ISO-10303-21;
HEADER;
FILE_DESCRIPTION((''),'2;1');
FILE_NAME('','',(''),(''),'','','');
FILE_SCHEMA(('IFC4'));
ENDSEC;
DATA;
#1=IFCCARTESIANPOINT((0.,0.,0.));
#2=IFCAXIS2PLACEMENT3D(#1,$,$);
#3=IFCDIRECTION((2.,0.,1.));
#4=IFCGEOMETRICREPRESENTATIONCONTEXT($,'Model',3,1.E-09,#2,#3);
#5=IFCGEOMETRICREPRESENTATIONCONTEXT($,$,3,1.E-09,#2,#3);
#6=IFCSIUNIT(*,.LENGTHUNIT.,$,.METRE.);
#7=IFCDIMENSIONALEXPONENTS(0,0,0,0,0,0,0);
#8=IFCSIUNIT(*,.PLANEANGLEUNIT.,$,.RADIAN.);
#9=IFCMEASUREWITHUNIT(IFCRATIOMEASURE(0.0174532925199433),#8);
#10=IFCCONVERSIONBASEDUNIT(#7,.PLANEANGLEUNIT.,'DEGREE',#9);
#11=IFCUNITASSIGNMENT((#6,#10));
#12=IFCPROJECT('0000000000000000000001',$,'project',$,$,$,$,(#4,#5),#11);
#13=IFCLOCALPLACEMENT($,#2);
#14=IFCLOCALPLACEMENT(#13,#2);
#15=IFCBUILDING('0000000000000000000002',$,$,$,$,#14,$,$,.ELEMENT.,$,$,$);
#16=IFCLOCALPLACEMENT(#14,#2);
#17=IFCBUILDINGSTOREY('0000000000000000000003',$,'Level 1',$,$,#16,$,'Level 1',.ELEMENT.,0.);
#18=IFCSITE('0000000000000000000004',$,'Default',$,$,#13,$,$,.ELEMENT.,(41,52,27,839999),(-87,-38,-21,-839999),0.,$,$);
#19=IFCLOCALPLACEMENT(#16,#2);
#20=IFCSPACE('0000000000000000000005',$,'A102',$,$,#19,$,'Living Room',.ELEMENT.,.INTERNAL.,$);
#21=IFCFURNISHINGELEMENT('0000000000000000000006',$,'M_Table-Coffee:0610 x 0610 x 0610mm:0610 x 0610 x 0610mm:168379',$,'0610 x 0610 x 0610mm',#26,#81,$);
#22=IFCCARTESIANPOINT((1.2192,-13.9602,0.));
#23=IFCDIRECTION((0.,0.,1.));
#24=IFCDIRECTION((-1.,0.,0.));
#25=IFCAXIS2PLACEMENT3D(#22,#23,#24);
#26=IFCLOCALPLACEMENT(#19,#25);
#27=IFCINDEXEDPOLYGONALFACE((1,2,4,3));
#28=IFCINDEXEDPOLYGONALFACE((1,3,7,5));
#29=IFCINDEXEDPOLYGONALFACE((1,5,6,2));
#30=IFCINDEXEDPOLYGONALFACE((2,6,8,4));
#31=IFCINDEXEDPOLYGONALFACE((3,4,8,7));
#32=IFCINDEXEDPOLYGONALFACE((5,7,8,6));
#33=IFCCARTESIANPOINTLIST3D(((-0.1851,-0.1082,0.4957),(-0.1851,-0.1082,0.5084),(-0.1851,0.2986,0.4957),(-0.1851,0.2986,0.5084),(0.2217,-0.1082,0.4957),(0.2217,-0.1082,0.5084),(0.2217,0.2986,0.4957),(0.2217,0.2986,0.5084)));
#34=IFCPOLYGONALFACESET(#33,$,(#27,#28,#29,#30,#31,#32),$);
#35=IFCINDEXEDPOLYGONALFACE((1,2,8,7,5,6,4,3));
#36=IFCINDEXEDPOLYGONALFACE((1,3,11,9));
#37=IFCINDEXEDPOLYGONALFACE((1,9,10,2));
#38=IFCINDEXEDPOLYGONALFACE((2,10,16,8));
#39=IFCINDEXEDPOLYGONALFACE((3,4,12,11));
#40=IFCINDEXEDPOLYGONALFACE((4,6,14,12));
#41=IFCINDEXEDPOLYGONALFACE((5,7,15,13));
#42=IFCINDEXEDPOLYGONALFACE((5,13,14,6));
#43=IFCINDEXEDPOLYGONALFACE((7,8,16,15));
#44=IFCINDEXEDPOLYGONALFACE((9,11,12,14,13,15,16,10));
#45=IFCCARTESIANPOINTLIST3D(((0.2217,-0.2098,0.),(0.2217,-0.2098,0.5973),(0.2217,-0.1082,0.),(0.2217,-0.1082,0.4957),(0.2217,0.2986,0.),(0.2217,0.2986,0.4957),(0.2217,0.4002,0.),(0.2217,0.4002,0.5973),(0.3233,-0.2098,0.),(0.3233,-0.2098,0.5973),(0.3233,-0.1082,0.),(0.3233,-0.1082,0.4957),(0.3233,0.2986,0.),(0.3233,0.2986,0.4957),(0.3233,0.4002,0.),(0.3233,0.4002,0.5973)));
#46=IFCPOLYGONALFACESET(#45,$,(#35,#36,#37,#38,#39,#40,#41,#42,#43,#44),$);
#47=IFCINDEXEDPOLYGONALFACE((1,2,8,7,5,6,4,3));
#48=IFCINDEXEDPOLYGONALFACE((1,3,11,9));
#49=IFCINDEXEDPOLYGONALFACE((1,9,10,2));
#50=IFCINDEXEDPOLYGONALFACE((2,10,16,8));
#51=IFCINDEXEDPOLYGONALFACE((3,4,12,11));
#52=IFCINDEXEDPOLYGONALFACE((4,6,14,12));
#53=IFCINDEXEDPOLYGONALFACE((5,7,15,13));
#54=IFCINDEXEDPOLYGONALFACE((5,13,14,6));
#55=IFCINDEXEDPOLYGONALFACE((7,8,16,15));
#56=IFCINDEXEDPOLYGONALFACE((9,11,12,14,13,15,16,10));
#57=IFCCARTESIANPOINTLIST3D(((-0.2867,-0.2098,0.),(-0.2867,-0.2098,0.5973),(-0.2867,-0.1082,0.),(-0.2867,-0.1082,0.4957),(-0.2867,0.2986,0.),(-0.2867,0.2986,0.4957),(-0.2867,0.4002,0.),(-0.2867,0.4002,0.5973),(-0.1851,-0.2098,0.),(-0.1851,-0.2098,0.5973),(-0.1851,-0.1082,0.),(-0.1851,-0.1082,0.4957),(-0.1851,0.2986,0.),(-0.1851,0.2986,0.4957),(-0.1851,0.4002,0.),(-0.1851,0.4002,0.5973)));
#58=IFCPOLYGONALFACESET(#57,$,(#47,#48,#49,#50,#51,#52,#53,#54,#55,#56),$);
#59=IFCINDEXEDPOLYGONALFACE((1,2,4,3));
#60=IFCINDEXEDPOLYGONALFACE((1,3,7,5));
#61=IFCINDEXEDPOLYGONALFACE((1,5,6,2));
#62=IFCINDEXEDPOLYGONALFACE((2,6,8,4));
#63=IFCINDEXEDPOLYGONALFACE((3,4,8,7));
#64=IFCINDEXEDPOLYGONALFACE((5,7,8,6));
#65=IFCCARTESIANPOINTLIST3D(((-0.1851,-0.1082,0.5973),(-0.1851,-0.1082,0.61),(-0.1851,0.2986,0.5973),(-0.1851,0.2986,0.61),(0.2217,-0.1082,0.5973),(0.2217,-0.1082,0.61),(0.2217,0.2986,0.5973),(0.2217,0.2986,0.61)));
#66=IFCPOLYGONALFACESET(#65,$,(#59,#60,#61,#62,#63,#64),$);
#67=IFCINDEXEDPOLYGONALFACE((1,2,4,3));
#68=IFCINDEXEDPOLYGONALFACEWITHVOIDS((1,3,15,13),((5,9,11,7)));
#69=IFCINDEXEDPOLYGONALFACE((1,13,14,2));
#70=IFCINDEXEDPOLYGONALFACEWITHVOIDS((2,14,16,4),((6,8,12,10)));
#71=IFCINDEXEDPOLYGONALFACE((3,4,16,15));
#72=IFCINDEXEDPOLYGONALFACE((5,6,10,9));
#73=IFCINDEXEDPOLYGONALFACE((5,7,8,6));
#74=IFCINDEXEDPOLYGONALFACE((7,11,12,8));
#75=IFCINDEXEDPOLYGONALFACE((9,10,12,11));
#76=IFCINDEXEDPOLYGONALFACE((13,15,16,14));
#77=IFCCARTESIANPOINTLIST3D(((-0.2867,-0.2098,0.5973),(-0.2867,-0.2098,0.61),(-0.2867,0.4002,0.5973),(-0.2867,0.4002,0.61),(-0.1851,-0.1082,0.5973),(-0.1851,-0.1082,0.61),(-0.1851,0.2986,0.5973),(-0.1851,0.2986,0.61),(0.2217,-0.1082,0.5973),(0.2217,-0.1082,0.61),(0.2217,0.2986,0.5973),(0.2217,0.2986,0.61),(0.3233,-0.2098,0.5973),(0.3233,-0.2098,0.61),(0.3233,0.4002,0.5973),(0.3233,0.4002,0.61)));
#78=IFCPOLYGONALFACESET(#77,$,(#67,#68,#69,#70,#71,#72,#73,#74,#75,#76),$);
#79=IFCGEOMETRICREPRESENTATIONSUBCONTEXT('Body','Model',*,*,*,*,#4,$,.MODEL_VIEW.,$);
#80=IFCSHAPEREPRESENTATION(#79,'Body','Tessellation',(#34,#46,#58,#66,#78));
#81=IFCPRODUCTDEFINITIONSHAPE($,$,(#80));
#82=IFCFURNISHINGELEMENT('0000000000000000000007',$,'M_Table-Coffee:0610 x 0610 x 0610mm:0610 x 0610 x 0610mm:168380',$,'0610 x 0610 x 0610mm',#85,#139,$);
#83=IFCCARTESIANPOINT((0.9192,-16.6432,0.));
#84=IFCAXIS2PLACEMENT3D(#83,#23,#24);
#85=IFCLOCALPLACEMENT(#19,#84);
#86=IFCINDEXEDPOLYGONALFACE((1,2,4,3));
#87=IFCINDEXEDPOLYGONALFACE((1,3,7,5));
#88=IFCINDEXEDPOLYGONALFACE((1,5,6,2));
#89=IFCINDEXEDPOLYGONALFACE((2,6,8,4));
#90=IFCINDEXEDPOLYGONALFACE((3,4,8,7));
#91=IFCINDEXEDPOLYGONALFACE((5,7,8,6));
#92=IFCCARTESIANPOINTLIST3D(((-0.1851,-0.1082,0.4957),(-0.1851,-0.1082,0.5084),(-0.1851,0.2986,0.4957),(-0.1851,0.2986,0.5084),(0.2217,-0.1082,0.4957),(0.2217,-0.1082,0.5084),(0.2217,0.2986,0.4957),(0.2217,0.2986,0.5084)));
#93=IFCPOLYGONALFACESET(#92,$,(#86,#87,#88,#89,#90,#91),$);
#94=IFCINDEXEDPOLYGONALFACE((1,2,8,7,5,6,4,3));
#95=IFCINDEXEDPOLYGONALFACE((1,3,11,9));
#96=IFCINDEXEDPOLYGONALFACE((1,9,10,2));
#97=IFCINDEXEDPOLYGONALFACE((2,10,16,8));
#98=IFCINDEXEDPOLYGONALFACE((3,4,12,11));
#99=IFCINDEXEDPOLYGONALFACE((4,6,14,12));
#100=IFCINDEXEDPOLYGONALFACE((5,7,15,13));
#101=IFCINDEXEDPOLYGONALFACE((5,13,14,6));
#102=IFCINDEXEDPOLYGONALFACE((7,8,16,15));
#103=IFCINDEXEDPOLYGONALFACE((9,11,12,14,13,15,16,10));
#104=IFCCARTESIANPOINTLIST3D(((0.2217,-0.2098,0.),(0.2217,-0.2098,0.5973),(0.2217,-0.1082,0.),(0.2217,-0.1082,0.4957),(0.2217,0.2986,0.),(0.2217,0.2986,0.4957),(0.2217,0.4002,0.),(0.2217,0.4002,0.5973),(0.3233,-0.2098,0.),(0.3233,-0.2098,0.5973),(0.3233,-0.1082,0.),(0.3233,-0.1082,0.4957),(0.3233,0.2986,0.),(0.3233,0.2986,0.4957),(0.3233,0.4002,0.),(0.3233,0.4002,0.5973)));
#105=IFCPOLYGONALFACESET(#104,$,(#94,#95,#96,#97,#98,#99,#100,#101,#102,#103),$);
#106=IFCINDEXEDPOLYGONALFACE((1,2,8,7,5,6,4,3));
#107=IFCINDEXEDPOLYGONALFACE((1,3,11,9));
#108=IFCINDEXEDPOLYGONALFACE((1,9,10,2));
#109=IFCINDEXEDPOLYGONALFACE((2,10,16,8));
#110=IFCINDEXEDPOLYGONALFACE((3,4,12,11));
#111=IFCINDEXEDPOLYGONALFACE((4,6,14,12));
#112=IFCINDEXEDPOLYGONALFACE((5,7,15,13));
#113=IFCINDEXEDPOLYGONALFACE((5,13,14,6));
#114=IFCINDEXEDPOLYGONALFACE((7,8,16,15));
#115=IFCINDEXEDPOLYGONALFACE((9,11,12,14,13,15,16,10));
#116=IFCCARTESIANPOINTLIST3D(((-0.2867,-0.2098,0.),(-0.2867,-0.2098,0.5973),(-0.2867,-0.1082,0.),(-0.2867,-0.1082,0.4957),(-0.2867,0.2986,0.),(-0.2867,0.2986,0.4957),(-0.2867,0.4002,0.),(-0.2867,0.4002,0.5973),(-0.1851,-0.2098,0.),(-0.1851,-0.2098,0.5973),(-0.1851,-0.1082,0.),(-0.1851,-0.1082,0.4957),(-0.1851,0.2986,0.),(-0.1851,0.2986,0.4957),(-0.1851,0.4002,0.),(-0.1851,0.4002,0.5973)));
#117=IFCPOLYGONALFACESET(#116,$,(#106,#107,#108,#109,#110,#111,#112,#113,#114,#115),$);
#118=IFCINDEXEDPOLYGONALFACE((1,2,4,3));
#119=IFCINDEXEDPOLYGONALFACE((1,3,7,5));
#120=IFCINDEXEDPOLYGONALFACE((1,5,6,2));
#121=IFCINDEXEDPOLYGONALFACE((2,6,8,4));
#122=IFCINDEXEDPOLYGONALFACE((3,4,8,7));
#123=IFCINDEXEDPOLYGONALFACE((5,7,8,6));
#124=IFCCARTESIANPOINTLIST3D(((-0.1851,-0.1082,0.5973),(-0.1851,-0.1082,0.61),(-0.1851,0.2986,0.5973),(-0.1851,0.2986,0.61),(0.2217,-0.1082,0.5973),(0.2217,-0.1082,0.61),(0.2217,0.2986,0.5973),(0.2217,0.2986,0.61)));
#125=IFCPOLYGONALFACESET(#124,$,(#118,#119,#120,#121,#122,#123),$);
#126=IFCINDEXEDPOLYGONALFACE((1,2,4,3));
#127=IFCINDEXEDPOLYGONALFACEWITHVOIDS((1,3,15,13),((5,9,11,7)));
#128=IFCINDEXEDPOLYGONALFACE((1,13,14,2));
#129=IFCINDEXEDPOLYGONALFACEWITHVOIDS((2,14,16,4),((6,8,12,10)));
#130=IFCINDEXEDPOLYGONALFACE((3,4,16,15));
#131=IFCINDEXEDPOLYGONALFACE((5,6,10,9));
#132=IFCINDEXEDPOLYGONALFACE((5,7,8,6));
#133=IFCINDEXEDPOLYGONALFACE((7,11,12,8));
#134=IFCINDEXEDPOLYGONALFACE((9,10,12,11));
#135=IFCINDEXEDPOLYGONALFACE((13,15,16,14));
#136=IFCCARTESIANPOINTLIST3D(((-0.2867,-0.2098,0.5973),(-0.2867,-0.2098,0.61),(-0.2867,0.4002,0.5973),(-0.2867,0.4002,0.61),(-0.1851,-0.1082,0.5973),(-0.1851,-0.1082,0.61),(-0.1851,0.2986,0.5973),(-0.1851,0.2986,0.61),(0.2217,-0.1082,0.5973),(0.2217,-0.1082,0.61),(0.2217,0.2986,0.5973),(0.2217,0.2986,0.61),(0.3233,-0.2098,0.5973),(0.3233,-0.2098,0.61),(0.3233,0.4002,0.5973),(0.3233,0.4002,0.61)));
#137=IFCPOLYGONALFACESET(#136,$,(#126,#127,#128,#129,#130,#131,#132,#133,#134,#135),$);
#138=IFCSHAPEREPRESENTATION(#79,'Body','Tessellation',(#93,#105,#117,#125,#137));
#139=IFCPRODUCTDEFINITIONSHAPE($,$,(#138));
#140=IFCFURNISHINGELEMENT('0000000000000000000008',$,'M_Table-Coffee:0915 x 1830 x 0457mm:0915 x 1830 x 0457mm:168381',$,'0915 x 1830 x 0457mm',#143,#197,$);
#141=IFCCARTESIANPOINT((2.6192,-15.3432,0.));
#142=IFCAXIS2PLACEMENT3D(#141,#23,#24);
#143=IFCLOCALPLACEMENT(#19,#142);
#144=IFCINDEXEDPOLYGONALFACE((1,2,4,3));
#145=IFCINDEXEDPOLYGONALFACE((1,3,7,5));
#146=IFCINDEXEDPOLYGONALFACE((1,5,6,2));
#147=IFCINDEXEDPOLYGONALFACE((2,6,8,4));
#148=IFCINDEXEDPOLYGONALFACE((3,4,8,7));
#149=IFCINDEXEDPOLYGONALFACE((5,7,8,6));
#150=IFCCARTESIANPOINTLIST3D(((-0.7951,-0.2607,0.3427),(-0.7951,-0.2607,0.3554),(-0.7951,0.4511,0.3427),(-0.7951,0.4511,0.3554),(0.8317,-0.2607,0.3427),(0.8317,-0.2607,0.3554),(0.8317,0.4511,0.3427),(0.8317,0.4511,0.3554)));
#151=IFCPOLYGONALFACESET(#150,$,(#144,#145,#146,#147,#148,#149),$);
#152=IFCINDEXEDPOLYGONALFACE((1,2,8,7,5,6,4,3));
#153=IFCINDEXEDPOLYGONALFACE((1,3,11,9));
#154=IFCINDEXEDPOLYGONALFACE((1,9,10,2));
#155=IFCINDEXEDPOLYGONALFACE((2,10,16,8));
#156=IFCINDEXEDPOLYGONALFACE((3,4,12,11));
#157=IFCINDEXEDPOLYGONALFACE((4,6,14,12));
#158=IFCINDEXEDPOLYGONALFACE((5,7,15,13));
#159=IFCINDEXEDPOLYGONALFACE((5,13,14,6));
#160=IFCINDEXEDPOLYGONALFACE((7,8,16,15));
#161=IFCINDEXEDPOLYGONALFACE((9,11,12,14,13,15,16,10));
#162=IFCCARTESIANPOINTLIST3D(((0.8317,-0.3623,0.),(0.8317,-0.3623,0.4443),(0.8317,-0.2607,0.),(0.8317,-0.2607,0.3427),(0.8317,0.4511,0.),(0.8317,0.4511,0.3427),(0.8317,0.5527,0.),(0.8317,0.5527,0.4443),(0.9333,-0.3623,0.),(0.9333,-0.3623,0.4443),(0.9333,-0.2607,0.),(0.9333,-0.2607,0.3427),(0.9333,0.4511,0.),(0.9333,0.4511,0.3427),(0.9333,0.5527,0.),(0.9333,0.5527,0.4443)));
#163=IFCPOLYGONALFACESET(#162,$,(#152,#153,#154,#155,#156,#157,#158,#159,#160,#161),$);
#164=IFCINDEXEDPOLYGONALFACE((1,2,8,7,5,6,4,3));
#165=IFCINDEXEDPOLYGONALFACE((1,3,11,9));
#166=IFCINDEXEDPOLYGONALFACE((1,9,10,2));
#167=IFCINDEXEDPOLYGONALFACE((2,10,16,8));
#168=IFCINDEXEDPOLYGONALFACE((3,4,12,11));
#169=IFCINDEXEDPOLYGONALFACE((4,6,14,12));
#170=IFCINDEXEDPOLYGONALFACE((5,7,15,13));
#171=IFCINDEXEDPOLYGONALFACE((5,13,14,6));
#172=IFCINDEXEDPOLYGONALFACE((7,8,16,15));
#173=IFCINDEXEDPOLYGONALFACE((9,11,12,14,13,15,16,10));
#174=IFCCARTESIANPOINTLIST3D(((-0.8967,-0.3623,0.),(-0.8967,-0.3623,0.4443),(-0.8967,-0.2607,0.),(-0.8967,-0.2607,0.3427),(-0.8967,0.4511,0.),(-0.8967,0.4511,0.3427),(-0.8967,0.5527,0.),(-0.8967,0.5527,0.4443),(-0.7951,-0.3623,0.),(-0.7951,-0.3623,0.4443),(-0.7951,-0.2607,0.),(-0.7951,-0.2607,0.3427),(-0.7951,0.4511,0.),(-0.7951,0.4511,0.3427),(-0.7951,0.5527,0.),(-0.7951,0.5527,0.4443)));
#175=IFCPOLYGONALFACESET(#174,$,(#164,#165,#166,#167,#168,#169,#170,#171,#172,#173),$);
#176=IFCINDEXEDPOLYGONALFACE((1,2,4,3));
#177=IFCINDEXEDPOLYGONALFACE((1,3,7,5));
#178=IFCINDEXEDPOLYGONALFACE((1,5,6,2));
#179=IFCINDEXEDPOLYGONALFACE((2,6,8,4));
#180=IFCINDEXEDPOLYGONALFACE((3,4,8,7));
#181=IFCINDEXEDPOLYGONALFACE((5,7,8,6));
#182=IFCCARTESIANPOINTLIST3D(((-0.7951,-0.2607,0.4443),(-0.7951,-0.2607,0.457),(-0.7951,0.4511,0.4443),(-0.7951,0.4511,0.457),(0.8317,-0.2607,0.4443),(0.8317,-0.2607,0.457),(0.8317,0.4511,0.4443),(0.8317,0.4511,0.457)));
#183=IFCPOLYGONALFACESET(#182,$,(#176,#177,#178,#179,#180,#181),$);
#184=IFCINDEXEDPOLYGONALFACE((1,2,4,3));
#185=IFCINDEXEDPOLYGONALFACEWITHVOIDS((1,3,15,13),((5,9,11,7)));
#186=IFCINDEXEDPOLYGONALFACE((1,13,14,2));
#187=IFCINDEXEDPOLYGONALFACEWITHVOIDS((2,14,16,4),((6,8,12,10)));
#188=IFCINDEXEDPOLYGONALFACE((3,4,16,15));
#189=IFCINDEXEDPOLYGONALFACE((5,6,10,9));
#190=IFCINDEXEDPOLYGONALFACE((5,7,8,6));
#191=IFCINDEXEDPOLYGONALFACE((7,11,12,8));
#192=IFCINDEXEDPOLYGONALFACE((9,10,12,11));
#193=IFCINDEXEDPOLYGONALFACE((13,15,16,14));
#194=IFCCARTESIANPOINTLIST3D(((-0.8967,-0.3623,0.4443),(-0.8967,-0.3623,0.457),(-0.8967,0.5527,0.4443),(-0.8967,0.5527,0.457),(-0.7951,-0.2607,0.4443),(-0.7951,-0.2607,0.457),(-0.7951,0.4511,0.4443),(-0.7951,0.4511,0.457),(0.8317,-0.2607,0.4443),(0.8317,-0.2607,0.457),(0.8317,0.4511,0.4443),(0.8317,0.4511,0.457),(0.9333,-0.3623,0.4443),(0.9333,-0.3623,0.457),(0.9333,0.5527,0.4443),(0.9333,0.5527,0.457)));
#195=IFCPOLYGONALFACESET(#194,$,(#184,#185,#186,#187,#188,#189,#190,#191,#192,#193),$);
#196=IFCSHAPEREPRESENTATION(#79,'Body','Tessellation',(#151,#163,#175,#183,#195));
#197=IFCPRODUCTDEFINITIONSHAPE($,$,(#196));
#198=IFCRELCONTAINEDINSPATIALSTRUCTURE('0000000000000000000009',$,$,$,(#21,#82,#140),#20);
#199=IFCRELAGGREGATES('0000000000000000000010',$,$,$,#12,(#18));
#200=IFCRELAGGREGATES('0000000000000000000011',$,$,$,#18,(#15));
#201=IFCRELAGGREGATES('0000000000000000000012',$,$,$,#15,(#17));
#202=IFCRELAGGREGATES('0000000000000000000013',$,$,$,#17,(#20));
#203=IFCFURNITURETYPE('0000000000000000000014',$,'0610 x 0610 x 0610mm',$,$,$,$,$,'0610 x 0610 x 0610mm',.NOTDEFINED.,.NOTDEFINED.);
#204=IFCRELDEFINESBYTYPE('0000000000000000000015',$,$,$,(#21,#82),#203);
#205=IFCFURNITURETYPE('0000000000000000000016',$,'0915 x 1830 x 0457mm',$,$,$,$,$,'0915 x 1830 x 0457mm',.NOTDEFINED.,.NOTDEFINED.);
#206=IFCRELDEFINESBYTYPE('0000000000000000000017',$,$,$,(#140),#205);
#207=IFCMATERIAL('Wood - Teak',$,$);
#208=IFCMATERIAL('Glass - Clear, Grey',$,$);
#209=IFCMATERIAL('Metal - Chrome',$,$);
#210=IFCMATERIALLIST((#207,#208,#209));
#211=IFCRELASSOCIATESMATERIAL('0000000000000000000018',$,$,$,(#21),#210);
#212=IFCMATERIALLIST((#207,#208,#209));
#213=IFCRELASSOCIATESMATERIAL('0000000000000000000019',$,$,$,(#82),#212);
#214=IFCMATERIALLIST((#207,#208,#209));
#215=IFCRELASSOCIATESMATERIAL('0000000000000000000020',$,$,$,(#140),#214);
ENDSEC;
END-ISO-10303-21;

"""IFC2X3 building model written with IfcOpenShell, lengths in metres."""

from ifc_helpers import new_model, entity, si_unit, converted_unit, direction, frame, origin, origin_2d_with_axis, place, context, subcontext, project, spatial, polyline, rectangle, outline, extrude, source, transform, mapped, material, material_list, type_object, type_shapes, element, save


model = new_model("IFC2X3")

# Units and contexts
model_context = context("Model", 3, precision=1e-09, world=origin(), true_north=direction((2.0, 0.0, 1.0)))
context_of_model = context(None, 3, precision=1e-09, world=origin(), true_north=direction((2.0, 0.0, 1.0)))
body_context = subcontext(model_context, "Body", "Model", "MODEL_VIEW")
ifc_project = project(units=[si_unit("LENGTHUNIT", "METRE"), converted_unit("PLANEANGLEUNIT", "DEGREE", entity("IfcRatioMeasure", 0.0174532925199433), si_unit("PLANEANGLEUNIT", "RADIAN"), dimensions=[0, 0, 0, 0, 0, 0, 0])], contexts=[model_context, context_of_model])

# Site, building, storey
site_placement = place(None, origin())
site = spatial("IfcSite", under=ifc_project, at=site_placement, Name="Default", CompositionType="ELEMENT", RefLatitude=(41, 52, 27, 839999), RefLongitude=(-87, -38, -21, -839999), RefElevation=0.0)
building_placement = place(site_placement, origin())
building = spatial("IfcBuilding", under=site, at=building_placement, CompositionType="ELEMENT")
storey_placement = place(building_placement, origin())
storey = spatial("IfcBuildingStorey", under=building, at=storey_placement, Name="Level 1", LongName="Level 1", CompositionType="ELEMENT", Elevation=0.0)

# Shared definitions
space_1_placement = place(storey_placement, origin())
space_1 = spatial("IfcSpace", under=storey, at=space_1_placement, Name="A102", LongName="Living Room", CompositionType="ELEMENT", InteriorOrExteriorSpace="INTERNAL")

# Furnishing elements
ifc_material_1 = material(Name="Wood - Teak")
ifc_material_2 = material(Name="Glass - Clear, Grey")
ifc_material_3 = material(Name="Metal - Chrome")
ifc_material_list_1 = material_list([ifc_material_1, ifc_material_2, ifc_material_3])
furniture_type_1 = type_object("IfcFurnitureType", Name="0610 x 0610 x 0610mm", ElementType="0610 x 0610 x 0610mm", AssemblyPlace="NOTDEFINED")
shared_shape_1 = source(origin(), body_context, "Body", "SweptSolid", [
    extrude(rectangle(XDim=0.4068, YDim=0.4068, at=origin_2d_with_axis()), frame((0.0183, 0.0952, 0.4957), z_axis=(0.0, 0.0, 1.0), x_axis=(-1.0, 0.0, 0.0)), (0.0, 0.0, 1.0), 0.0127),
    extrude(outline(polyline([(-0.2732, -0.305), (0.324, -0.305), (0.324, 0.305), (-0.2732, 0.305), (-0.2732, 0.2034), (0.2225, 0.2034), (0.2225, -0.2034), (-0.2732, -0.2034), (-0.2732, -0.305)])), frame((0.2217, 0.0952, 0.2732), z_axis=(1.0, 0.0, 0.0), x_axis=(0.0, 0.0, 1.0)), (0.0, 0.0, 1.0), 0.1016),
    extrude(outline(polyline([(-0.305, -0.3241), (0.305, -0.3241), (0.305, 0.2733), (0.2034, 0.2733), (0.2034, -0.2224), (-0.2034, -0.2224), (-0.2034, 0.2733), (-0.305, 0.2733), (-0.305, -0.3241)])), frame((-0.2867, 0.0952, 0.2733), z_axis=(1.0, 0.0, 0.0), x_axis=(0.0, -1.0, 0.0)), (0.0, 0.0, 1.0), 0.1016),
    extrude(rectangle(XDim=0.4068, YDim=0.4068, at=origin_2d_with_axis()), frame((0.0183, 0.0952, 0.5973), z_axis=(0.0, 0.0, 1.0), x_axis=(-1.0, 0.0, 0.0)), (0.0, 0.0, 1.0), 0.0127),
    extrude(outline(polyline([(-0.305, -0.305), (0.305, -0.305), (0.305, 0.305), (-0.305, 0.305), (-0.305, -0.305)]), holes=[polyline([(-0.2034, -0.2034), (-0.2034, 0.2034), (0.2034, 0.2034), (0.2034, -0.2034), (-0.2034, -0.2034)])]), frame((0.0183, 0.0952, 0.5973), z_axis=(0.0, 0.0, 1.0), x_axis=(-1.0, 0.0, 0.0)), (0.0, 0.0, 1.0), 0.0127),
])
type_shapes(furniture_type_1, [shared_shape_1])
furnishing_1_placement = place(space_1_placement, frame((1.2192, -13.9602, 0.0), z_axis=(0.0, 0.0, 1.0), x_axis=(-1.0, 0.0, 0.0)))
element("IfcFurnishingElement", 1, at=furnishing_1_placement, inside=space_1, type_object=furniture_type_1, material=ifc_material_list_1, Name="M_Table-Coffee:0610 x 0610 x 0610mm:0610 x 0610 x 0610mm:168379", ObjectType="0610 x 0610 x 0610mm", context=body_context, shape_type="MappedRepresentation", body=[
    mapped(shared_shape_1, transform((0.0, 0.0, 0.0), scale=1.0)),
])
ifc_material_list_2 = material_list([ifc_material_1, ifc_material_2, ifc_material_3])
furnishing_2_placement = place(space_1_placement, frame((0.9192, -16.6432, 0.0), z_axis=(0.0, 0.0, 1.0), x_axis=(-1.0, 0.0, 0.0)))
element("IfcFurnishingElement", 2, at=furnishing_2_placement, inside=space_1, type_object=furniture_type_1, material=ifc_material_list_2, Name="M_Table-Coffee:0610 x 0610 x 0610mm:0610 x 0610 x 0610mm:168380", ObjectType="0610 x 0610 x 0610mm", context=body_context, shape_type="MappedRepresentation", body=[
    mapped(shared_shape_1, transform((0.0, 0.0, 0.0), scale=1.0)),
])
ifc_material_list_3 = material_list([ifc_material_1, ifc_material_2, ifc_material_3])
furniture_type_2 = type_object("IfcFurnitureType", Name="0915 x 1830 x 0457mm", ElementType="0915 x 1830 x 0457mm", AssemblyPlace="NOTDEFINED")
shared_shape_2 = source(origin(), body_context, "Body", "SweptSolid", [
    extrude(rectangle(XDim=1.6268, YDim=0.7118, at=origin_2d_with_axis()), frame((0.0183, 0.0952, 0.3427), z_axis=(0.0, 0.0, 1.0), x_axis=(-1.0, 0.0, 0.0)), (0.0, 0.0, 1.0), 0.0127),
    extrude(outline(polyline([(-0.1967, -0.4575), (0.2475, -0.4575), (0.2475, 0.4575), (-0.1967, 0.4575), (-0.1967, 0.3559), (0.146, 0.3559), (0.146, -0.3559), (-0.1967, -0.3559), (-0.1967, -0.4575)])), frame((0.8317, 0.0952, 0.1967), z_axis=(1.0, 0.0, 0.0), x_axis=(0.0, 0.0, 1.0)), (0.0, 0.0, 1.0), 0.1016),
    extrude(outline(polyline([(-0.4575, -0.2476), (0.4575, -0.2476), (0.4575, 0.1968), (0.3559, 0.1968), (0.3559, -0.1459), (-0.3559, -0.1459), (-0.3559, 0.1968), (-0.4575, 0.1968), (-0.4575, -0.2476)])), frame((-0.8967, 0.0952, 0.1968), z_axis=(1.0, 0.0, 0.0), x_axis=(0.0, -1.0, 0.0)), (0.0, 0.0, 1.0), 0.1016),
    extrude(rectangle(XDim=1.6268, YDim=0.7118, at=origin_2d_with_axis()), frame((0.0183, 0.0952, 0.4443), z_axis=(0.0, 0.0, 1.0), x_axis=(-1.0, 0.0, 0.0)), (0.0, 0.0, 1.0), 0.0127),
    extrude(outline(polyline([(-0.915, -0.4575), (0.915, -0.4575), (0.915, 0.4575), (-0.915, 0.4575), (-0.915, -0.4575)]), holes=[polyline([(-0.8134, -0.3559), (-0.8134, 0.3559), (0.8134, 0.3559), (0.8134, -0.3559), (-0.8134, -0.3559)])]), frame((0.0183, 0.0952, 0.4443), z_axis=(0.0, 0.0, 1.0), x_axis=(-1.0, 0.0, 0.0)), (0.0, 0.0, 1.0), 0.0127),
])
type_shapes(furniture_type_2, [shared_shape_2])
furnishing_3_placement = place(space_1_placement, frame((2.6192, -15.3432, 0.0), z_axis=(0.0, 0.0, 1.0), x_axis=(-1.0, 0.0, 0.0)))
element("IfcFurnishingElement", 3, at=furnishing_3_placement, inside=space_1, type_object=furniture_type_2, material=ifc_material_list_3, Name="M_Table-Coffee:0915 x 1830 x 0457mm:0915 x 1830 x 0457mm:168381", ObjectType="0915 x 1830 x 0457mm", context=body_context, shape_type="MappedRepresentation", body=[
    mapped(shared_shape_2, transform((0.0, 0.0, 0.0), scale=1.0)),
])

save(model, "model.ifc")
